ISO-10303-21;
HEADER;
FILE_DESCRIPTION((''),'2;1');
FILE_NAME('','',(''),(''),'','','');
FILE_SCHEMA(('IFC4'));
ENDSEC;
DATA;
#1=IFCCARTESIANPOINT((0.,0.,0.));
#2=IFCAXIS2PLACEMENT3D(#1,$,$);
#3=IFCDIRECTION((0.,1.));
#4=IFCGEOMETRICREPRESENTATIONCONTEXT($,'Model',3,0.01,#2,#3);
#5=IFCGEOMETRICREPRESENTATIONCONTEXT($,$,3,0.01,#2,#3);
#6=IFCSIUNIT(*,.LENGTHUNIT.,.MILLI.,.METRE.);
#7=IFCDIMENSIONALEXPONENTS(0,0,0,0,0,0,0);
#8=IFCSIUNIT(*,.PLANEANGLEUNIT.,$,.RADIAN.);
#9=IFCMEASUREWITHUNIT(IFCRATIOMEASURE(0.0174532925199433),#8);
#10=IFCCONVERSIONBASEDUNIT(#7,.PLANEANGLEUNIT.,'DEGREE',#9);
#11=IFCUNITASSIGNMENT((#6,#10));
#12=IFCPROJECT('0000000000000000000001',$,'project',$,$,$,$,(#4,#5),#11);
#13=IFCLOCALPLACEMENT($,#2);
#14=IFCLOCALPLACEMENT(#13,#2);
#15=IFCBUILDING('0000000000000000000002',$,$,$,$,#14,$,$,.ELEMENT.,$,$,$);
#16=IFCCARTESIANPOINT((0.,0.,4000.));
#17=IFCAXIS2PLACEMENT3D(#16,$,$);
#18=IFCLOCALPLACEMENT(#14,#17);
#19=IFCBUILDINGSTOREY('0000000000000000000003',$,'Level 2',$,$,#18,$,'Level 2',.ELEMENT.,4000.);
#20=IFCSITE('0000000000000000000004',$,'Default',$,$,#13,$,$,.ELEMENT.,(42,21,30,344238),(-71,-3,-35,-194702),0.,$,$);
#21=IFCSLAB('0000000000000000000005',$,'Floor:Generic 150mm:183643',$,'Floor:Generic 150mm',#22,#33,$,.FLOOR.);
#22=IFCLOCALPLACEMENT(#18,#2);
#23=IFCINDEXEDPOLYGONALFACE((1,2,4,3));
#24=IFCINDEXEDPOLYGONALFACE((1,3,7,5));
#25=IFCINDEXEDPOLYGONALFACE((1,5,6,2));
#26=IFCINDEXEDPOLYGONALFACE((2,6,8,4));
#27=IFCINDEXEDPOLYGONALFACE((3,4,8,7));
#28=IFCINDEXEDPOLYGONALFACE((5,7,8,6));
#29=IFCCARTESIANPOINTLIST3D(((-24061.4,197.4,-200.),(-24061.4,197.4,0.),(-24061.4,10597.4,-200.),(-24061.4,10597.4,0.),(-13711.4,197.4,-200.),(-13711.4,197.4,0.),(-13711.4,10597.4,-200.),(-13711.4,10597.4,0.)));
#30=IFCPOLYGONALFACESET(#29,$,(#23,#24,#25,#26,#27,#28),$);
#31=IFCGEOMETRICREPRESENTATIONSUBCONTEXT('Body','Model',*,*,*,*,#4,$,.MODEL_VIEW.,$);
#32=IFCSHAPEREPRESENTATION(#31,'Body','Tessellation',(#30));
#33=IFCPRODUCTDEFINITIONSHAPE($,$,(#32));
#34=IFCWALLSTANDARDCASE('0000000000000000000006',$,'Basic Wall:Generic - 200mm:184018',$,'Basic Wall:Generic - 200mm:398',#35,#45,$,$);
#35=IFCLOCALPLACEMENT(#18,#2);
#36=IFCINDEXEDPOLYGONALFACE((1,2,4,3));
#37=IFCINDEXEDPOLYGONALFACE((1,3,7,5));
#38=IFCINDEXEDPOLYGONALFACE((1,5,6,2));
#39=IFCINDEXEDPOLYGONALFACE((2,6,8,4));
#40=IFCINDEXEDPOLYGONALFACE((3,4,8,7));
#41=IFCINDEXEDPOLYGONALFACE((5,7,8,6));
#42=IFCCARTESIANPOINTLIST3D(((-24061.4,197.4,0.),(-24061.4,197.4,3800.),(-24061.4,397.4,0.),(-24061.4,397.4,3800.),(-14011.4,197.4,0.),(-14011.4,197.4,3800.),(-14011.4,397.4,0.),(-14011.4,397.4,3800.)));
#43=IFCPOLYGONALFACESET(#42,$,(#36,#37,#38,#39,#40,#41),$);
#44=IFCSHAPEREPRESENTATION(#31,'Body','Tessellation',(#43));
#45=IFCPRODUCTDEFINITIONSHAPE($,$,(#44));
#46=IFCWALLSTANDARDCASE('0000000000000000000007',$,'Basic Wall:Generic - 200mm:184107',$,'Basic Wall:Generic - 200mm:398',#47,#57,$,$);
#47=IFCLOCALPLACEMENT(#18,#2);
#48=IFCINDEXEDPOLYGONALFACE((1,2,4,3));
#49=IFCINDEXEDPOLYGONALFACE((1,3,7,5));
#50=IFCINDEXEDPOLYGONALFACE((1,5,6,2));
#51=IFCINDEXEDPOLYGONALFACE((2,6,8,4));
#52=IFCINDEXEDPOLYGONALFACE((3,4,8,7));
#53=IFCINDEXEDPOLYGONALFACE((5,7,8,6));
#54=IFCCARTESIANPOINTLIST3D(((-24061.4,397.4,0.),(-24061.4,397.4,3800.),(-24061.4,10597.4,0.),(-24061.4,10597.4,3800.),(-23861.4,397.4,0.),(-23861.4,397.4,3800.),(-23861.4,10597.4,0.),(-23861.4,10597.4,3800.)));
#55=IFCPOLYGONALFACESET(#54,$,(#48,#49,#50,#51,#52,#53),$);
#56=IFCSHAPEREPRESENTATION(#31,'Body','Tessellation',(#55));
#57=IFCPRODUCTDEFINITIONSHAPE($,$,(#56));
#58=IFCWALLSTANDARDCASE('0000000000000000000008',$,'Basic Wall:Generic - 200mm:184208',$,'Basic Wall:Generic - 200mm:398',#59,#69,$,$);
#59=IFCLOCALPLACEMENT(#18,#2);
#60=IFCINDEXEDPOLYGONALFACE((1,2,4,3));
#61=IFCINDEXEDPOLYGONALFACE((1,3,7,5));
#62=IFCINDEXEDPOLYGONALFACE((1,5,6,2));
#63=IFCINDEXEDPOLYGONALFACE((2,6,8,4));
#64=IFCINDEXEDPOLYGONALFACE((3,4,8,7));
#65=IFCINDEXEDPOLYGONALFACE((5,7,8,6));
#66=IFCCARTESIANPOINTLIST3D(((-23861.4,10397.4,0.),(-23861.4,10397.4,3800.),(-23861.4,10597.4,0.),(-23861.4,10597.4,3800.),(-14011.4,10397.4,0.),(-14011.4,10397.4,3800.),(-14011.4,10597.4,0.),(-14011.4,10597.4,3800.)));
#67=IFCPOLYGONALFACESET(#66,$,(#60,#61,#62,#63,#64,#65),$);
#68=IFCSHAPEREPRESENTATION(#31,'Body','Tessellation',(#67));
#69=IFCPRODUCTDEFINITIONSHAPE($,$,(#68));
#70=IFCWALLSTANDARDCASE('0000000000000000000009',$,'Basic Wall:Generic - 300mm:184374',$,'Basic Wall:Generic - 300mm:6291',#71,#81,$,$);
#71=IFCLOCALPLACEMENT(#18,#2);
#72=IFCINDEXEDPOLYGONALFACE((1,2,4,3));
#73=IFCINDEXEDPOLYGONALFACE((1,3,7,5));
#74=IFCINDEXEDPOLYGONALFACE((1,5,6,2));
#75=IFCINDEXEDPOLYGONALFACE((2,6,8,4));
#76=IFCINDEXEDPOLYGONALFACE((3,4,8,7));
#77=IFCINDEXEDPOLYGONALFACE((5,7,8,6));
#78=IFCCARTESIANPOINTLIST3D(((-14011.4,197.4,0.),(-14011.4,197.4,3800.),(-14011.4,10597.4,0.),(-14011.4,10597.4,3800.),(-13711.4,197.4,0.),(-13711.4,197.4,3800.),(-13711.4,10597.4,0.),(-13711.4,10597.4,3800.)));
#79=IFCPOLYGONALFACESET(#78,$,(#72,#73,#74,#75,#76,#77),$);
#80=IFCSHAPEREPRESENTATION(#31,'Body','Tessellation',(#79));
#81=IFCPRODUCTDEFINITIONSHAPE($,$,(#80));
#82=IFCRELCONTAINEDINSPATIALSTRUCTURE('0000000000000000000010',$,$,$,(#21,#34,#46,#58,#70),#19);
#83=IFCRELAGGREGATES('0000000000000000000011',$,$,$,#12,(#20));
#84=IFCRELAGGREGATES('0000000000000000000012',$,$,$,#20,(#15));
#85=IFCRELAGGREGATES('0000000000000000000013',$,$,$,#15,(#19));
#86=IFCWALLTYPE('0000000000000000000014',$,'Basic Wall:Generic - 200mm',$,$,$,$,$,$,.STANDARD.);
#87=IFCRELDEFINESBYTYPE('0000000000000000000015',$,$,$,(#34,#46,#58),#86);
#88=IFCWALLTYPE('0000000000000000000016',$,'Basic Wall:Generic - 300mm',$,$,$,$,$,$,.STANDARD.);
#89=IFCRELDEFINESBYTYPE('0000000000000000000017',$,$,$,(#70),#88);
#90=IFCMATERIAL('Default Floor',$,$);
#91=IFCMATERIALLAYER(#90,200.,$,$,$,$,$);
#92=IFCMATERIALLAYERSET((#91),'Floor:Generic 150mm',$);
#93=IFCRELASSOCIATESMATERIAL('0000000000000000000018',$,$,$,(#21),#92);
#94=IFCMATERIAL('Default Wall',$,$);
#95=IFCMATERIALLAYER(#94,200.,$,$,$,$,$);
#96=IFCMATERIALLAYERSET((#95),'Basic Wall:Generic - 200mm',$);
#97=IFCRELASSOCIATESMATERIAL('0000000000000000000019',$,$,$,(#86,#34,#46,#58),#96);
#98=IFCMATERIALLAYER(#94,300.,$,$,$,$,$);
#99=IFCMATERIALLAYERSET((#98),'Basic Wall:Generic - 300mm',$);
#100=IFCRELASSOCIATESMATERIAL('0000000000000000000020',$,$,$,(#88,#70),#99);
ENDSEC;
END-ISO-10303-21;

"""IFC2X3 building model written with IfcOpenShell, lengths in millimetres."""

from ifc_helpers import new_model, entity, si_unit, converted_unit, direction, frame, frame_2d, origin, place, context, subcontext, project, spatial, rectangle, extrude, material, layer, layer_set, layer_usage, type_object, element, save


model = new_model("IFC2X3")

# Units and contexts
model_context = context("Model", 3, precision=0.01, world=origin(), true_north=direction((0.0, 1.0)))
context_of_model = context(None, 3, precision=0.01, world=origin(), true_north=direction((0.0, 1.0)))
body_context = subcontext(model_context, "Body", "Model", "MODEL_VIEW")
ifc_project = project(units=[si_unit("LENGTHUNIT", "METRE", prefix="MILLI"), converted_unit("PLANEANGLEUNIT", "DEGREE", entity("IfcRatioMeasure", 0.0174532925199433), si_unit("PLANEANGLEUNIT", "RADIAN"), dimensions=[0, 0, 0, 0, 0, 0, 0])], contexts=[model_context, context_of_model])

# Site, building, storey
site_placement = place(None, origin())
site = spatial("IfcSite", under=ifc_project, at=site_placement, Name="Default", CompositionType="ELEMENT", RefLatitude=(42, 21, 30, 344238), RefLongitude=(-71, -3, -35, -194702), RefElevation=0.0)
building_placement = place(site_placement, origin())
building = spatial("IfcBuilding", under=site, at=building_placement, CompositionType="ELEMENT")
storey_placement = place(building_placement, frame((0.0, 0.0, 4000.0)))
storey = spatial("IfcBuildingStorey", under=building, at=storey_placement, Name="Level 2", LongName="Level 2", CompositionType="ELEMENT", Elevation=4000.0)

# Slab
ifc_material_1 = material(Name="Default Floor")
ifc_layer_1 = layer(ifc_material_1, 200.0)
ifc_layer_set_1 = layer_set([ifc_layer_1], Name="Floor:Generic 150mm")
ifc_layer_usage_1 = layer_usage(ifc_layer_set_1, "AXIS3", "POSITIVE", 0.0)
slab_placement = place(storey_placement, origin())
element("IfcSlab", 1, at=slab_placement, inside=storey, material=ifc_layer_usage_1, Name="Floor:Generic 150mm:183643", ObjectType="Floor:Generic 150mm", PredefinedType="FLOOR", context=body_context, shape_type="SweptSolid", body=[
    extrude(rectangle(XDim=10400.0, YDim=10350.0, at=frame_2d((0.0, 0.0), x_axis=(1.0, 0.0))), frame((-18886.4, 5397.4, 0.0), z_axis=(0.0, 0.0, -1.0), x_axis=(0.0, 1.0, 0.0)), (0.0, 0.0, 1.0), 200.0),
])

# Walls
ifc_material_2 = material(Name="Default Wall")
ifc_layer_2 = layer(ifc_material_2, 200.0)
ifc_layer_set_2 = layer_set([ifc_layer_2], Name="Basic Wall:Generic - 200mm")
ifc_layer_usage_2 = layer_usage(ifc_layer_set_2, "AXIS2", "NEGATIVE", 100.0)
wall_type_1 = type_object("IfcWallType", Name="Basic Wall:Generic - 200mm", PredefinedType="STANDARD", material=ifc_layer_set_2)
wall_1_placement = place(storey_placement, frame((-14011.4, 297.4, 0.0), z_axis=(0.0, 0.0, 1.0), x_axis=(-1.0, 0.0, 0.0)))
element("IfcWallStandardCase", 2, at=wall_1_placement, inside=storey, type_object=wall_type_1, material=ifc_layer_usage_2, Name="Basic Wall:Generic - 200mm:184018", ObjectType="Basic Wall:Generic - 200mm:398", context=body_context, shape_type="SweptSolid", body=[
    extrude(rectangle(XDim=10050.0, YDim=200.0, at=frame_2d((5025.0, 0.0), x_axis=(-1.0, 0.0))), origin(), (0.0, 0.0, 1.0), 3800.0),
])
ifc_layer_usage_3 = layer_usage(ifc_layer_set_2, "AXIS2", "NEGATIVE", 100.0)
wall_2_placement = place(storey_placement, frame((-23961.4, 397.4, 0.0), z_axis=(0.0, 0.0, 1.0), x_axis=(0.0, 1.0, 0.0)))
element("IfcWallStandardCase", 3, at=wall_2_placement, inside=storey, type_object=wall_type_1, material=ifc_layer_usage_3, Name="Basic Wall:Generic - 200mm:184107", ObjectType="Basic Wall:Generic - 200mm:398", context=body_context, shape_type="SweptSolid", body=[
    extrude(rectangle(XDim=10200.0, YDim=200.0, at=frame_2d((5100.0, 0.0), x_axis=(-1.0, 0.0))), origin(), (0.0, 0.0, 1.0), 3800.0),
])
ifc_layer_usage_4 = layer_usage(ifc_layer_set_2, "AXIS2", "NEGATIVE", 100.0)
wall_3_placement = place(storey_placement, frame((-23861.4, 10497.4, 0.0)))
element("IfcWallStandardCase", 4, at=wall_3_placement, inside=storey, type_object=wall_type_1, material=ifc_layer_usage_4, Name="Basic Wall:Generic - 200mm:184208", ObjectType="Basic Wall:Generic - 200mm:398", context=body_context, shape_type="SweptSolid", body=[
    extrude(rectangle(XDim=9850.0, YDim=200.0, at=frame_2d((4925.0, 0.0), x_axis=(-1.0, 0.0))), origin(), (0.0, 0.0, 1.0), 3800.0),
])
ifc_layer_3 = layer(ifc_material_2, 300.0)
ifc_layer_set_3 = layer_set([ifc_layer_3], Name="Basic Wall:Generic - 300mm")
ifc_layer_usage_5 = layer_usage(ifc_layer_set_3, "AXIS2", "NEGATIVE", 150.0)
wall_type_2 = type_object("IfcWallType", Name="Basic Wall:Generic - 300mm", PredefinedType="STANDARD", material=ifc_layer_set_3)
wall_4_placement = place(storey_placement, frame((-13861.4, 10597.4, 0.0), z_axis=(0.0, 0.0, 1.0), x_axis=(0.0, -1.0, 0.0)))
element("IfcWallStandardCase", 5, at=wall_4_placement, inside=storey, type_object=wall_type_2, material=ifc_layer_usage_5, Name="Basic Wall:Generic - 300mm:184374", ObjectType="Basic Wall:Generic - 300mm:6291", context=body_context, shape_type="SweptSolid", body=[
    extrude(rectangle(XDim=10400.0, YDim=300.0, at=frame_2d((5200.0, 0.0), x_axis=(-1.0, 0.0))), origin(), (0.0, 0.0, 1.0), 3800.0),
])

save(model, "model.ifc")
